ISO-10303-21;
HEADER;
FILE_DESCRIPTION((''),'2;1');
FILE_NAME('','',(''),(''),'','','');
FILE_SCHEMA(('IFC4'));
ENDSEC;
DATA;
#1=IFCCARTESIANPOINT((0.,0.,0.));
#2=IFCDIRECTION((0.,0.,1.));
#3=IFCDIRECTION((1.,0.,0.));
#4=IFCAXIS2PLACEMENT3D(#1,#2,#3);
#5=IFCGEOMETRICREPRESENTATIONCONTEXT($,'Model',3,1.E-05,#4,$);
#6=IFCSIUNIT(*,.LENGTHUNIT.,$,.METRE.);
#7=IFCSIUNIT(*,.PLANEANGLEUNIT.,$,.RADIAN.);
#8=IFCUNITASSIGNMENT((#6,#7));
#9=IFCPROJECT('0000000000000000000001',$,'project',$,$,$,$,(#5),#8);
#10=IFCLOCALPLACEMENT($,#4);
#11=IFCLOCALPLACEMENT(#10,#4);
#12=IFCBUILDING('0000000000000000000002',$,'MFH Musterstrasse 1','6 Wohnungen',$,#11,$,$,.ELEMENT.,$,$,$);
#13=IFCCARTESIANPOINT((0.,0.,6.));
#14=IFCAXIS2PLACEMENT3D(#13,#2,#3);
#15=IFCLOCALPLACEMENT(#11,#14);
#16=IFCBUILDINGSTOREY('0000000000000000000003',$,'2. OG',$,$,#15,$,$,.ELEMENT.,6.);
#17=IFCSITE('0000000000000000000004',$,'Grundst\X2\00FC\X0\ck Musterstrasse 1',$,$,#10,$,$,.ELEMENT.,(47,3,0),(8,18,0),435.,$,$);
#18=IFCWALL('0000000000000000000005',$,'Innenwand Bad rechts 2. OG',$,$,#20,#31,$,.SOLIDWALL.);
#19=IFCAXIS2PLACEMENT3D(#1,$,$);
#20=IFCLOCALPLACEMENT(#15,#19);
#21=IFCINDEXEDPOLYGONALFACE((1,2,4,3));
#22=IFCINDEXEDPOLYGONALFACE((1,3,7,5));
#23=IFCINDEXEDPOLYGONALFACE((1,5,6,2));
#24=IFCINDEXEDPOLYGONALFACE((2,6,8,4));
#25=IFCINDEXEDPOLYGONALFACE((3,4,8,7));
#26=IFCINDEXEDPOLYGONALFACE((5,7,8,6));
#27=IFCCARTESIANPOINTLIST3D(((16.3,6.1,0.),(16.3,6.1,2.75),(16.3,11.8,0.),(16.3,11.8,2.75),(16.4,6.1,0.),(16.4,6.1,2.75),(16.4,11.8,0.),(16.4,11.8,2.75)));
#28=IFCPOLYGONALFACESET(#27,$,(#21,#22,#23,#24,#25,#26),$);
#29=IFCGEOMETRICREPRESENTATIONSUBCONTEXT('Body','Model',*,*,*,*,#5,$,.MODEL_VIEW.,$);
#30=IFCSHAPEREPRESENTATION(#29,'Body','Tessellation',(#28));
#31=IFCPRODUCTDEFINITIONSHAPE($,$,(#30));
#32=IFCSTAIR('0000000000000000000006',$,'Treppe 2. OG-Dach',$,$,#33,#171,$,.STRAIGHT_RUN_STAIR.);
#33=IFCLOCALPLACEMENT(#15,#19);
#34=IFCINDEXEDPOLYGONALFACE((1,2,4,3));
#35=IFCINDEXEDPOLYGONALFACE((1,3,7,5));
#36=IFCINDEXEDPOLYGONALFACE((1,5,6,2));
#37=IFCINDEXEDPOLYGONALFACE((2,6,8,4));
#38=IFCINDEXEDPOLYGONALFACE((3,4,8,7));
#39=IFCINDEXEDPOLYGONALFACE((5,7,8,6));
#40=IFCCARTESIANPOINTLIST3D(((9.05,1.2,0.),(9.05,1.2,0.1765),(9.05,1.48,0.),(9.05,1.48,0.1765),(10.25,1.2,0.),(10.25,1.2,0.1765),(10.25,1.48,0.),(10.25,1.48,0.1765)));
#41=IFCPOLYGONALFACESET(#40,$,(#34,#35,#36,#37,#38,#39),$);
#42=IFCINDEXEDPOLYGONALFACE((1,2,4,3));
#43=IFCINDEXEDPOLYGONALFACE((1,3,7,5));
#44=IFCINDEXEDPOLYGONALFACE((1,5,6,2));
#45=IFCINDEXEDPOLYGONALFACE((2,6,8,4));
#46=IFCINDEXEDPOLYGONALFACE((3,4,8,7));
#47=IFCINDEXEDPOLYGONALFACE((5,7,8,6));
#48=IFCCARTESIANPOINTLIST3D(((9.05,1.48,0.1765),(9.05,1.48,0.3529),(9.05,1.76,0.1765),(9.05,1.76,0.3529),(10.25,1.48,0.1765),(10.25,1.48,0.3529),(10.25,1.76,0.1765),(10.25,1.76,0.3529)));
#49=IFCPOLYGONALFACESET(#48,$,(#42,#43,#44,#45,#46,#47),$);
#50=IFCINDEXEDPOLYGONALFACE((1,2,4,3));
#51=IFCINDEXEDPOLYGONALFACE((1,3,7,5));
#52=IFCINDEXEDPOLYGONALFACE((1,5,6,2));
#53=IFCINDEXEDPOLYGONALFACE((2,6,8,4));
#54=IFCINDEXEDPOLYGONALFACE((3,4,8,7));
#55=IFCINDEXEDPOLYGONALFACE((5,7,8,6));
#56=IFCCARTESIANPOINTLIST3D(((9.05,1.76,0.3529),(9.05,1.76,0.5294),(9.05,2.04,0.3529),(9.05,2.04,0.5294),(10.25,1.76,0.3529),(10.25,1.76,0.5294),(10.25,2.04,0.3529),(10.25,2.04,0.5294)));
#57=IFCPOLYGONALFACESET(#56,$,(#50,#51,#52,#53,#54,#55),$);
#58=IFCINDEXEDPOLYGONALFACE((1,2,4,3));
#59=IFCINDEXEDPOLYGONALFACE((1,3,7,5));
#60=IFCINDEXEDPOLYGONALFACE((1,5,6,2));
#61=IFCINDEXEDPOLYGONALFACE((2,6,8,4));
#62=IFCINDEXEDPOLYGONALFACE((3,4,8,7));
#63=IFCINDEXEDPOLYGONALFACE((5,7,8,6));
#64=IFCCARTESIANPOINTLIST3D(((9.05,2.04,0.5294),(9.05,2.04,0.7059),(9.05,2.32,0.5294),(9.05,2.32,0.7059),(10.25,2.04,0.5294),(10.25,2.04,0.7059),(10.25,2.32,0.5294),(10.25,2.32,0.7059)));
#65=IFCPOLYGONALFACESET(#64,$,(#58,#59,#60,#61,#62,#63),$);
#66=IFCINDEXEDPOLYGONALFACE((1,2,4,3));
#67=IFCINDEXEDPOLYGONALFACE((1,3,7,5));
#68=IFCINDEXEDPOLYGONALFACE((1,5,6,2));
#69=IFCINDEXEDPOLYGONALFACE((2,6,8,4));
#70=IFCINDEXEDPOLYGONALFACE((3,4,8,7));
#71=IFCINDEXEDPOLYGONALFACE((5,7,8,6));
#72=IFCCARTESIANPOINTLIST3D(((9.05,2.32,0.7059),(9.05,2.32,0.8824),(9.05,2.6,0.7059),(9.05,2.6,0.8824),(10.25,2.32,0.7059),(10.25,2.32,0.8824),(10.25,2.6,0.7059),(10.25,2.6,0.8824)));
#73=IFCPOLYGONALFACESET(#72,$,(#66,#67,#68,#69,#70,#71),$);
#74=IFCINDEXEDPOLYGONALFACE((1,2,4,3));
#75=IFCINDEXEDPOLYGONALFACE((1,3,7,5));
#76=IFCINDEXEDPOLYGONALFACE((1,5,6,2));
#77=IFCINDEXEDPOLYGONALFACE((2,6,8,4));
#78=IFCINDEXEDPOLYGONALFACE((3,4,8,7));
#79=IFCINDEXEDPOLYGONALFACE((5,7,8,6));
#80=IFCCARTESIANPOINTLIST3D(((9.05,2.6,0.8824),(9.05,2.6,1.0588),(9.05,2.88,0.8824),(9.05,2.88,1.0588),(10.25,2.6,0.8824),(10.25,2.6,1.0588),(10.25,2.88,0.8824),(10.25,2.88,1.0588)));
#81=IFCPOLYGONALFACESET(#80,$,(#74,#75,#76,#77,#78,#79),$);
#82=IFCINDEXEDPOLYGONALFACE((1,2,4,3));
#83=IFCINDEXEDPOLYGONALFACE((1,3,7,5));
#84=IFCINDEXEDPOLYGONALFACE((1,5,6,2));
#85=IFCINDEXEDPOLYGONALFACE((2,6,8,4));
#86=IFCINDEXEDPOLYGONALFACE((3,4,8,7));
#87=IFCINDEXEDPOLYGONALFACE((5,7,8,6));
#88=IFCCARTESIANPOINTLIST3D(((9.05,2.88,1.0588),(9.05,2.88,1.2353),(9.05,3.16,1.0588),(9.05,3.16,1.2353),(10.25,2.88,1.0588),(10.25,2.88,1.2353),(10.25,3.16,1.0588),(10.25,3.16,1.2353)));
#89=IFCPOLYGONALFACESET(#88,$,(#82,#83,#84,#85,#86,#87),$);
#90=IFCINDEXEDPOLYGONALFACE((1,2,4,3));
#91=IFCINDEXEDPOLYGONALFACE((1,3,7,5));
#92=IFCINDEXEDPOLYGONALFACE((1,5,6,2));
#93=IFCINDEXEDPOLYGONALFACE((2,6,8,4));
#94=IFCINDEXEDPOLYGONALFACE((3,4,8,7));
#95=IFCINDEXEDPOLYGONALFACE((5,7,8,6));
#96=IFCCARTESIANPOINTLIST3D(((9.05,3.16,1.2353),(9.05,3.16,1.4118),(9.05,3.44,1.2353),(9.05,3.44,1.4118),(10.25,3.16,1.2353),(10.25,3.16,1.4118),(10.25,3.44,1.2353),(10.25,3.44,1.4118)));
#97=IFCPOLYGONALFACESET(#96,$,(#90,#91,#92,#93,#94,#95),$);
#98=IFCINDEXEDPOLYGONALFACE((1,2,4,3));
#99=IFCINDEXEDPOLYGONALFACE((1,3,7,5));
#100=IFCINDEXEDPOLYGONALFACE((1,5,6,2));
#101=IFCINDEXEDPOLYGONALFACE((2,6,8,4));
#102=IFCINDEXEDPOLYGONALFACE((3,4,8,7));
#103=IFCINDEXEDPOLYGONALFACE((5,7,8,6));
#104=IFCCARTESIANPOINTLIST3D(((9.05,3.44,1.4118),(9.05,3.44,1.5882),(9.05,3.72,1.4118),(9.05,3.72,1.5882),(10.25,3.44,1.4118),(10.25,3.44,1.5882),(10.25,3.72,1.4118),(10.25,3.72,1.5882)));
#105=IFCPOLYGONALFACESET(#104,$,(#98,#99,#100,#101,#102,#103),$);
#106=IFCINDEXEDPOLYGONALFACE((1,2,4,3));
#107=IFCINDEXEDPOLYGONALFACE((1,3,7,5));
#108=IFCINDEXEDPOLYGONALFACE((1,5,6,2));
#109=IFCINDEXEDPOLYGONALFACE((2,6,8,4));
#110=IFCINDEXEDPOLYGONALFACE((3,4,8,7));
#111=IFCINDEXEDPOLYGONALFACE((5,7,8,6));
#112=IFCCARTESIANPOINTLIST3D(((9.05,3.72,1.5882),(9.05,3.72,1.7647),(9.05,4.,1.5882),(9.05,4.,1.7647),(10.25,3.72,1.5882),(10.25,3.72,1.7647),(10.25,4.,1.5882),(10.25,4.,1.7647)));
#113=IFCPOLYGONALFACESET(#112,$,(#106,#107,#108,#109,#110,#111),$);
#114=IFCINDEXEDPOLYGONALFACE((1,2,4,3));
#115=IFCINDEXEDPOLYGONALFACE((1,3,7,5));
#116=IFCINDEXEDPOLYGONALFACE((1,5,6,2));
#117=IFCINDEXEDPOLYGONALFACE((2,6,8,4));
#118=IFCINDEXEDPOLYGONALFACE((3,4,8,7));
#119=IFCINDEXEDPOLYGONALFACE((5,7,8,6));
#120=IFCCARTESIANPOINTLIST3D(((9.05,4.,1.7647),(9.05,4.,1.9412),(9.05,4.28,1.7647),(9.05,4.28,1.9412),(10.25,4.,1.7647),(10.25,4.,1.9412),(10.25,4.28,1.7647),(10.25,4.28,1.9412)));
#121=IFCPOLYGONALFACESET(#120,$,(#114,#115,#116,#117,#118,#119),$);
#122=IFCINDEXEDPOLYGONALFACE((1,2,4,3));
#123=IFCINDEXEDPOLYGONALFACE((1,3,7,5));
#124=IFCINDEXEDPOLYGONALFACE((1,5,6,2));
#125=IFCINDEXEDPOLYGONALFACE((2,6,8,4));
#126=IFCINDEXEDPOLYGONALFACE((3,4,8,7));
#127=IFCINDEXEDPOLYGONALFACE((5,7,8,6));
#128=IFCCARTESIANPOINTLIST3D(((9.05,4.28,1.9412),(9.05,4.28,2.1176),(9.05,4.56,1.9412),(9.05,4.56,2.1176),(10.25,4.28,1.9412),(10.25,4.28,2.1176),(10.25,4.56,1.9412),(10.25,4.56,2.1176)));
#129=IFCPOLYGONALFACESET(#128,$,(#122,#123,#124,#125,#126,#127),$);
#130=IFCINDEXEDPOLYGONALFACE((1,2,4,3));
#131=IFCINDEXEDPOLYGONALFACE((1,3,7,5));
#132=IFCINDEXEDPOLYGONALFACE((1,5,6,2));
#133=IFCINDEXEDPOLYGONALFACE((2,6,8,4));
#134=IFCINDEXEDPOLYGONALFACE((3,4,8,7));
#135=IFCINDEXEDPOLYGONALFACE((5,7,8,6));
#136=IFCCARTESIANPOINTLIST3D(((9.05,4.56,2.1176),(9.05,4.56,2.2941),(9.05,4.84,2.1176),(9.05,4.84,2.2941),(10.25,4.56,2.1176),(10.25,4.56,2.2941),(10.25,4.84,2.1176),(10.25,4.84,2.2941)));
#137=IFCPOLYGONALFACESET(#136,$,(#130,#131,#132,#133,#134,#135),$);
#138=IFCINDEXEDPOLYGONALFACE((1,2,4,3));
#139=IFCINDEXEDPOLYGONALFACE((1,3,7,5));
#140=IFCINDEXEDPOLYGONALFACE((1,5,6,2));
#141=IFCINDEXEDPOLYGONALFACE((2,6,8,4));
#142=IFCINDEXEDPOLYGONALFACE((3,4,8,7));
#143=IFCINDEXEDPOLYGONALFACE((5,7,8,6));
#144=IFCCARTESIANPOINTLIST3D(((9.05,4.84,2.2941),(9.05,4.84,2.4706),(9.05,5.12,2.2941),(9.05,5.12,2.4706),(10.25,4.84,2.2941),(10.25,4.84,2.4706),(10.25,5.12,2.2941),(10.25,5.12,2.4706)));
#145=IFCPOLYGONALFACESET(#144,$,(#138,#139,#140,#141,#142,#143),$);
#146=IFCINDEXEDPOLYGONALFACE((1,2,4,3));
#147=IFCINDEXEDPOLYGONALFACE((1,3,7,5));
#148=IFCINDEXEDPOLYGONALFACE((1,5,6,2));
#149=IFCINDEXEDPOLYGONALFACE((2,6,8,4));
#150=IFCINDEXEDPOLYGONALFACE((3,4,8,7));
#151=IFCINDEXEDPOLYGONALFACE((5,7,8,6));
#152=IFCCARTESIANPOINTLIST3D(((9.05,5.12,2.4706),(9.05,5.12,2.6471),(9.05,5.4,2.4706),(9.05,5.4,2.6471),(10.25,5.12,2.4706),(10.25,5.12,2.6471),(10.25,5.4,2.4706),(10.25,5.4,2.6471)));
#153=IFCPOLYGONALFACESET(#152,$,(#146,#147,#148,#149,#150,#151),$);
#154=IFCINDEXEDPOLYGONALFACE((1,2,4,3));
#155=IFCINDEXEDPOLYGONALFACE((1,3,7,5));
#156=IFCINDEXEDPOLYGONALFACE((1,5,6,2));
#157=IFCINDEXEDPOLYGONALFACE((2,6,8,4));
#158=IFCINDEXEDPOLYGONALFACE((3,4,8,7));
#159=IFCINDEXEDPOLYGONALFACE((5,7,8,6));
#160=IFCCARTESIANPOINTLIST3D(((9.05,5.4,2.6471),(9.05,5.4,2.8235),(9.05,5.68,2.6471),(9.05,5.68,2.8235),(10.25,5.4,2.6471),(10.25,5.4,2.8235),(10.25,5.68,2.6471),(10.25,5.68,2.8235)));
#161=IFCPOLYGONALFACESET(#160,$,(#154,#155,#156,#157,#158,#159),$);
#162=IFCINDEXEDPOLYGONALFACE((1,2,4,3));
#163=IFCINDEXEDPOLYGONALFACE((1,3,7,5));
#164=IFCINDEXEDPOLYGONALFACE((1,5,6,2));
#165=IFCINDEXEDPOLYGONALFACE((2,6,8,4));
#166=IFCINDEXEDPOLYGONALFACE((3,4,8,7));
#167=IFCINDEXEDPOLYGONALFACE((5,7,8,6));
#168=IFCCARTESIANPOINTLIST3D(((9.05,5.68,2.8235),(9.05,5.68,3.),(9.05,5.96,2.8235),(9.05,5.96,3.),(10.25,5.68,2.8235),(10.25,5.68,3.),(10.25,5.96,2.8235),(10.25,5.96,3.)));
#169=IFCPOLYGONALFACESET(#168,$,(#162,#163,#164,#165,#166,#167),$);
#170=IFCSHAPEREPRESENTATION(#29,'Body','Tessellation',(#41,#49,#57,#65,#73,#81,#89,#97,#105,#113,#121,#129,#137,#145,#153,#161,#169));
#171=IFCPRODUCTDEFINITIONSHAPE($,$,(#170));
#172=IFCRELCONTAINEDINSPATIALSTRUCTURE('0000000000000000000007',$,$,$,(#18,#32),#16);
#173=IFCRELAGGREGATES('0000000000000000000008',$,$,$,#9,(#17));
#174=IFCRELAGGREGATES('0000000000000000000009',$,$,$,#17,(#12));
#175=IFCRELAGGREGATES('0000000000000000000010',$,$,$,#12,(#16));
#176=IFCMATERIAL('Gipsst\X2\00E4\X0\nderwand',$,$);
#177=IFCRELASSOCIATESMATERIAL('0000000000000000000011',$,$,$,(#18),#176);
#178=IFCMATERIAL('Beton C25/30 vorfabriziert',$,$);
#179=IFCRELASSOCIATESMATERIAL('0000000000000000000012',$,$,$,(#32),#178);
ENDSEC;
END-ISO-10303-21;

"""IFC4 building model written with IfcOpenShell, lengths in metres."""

from ifc_helpers import new_model, si_unit, frame, frame_2d, origin_with_axes, place, context, subcontext, project, spatial, rectangle, extrude, material, element, save


model = new_model("IFC4")

# Units and contexts
model_context = context("Model", 3, precision=1e-05, world=origin_with_axes())
body_context = subcontext(model_context, "Body", "Model", "MODEL_VIEW")
ifc_project = project(units=[si_unit("LENGTHUNIT", "METRE"), si_unit("PLANEANGLEUNIT", "RADIAN")], contexts=[model_context])

# Site, building, storey
site_placement = place(None, origin_with_axes())
site = spatial("IfcSite", under=ifc_project, at=site_placement, Name="Grundstück Musterstrasse 1", CompositionType="ELEMENT", RefLatitude=(47, 3, 0), RefLongitude=(8, 18, 0), RefElevation=435.0)
building_placement = place(site_placement, origin_with_axes())
building = spatial("IfcBuilding", under=site, at=building_placement, Name="MFH Musterstrasse 1", Description="6 Wohnungen", CompositionType="ELEMENT")
storey_placement = place(building_placement, frame((0.0, 0.0, 6.0), z_axis=(0.0, 0.0, 1.0), x_axis=(1.0, 0.0, 0.0)))
storey = spatial("IfcBuildingStorey", under=building, at=storey_placement, Name="2. OG", CompositionType="ELEMENT", Elevation=6.0)

# Shared definitions
ifc_material_1 = material(Name="Gipsständerwand")

# Wall
wall_1_placement = place(storey_placement, origin_with_axes())
element("IfcWall", 1, at=wall_1_placement, inside=storey, material=ifc_material_1, Name="Innenwand Bad rechts 2. OG", PredefinedType="SOLIDWALL", context=body_context, shape_type="SweptSolid", body=[
    extrude(rectangle(XDim=0.1, YDim=5.7, at=frame_2d((0.05, 2.85), x_axis=(1.0, 0.0))), frame((16.3, 6.1, 0.0), z_axis=(0.0, 0.0, 1.0), x_axis=(1.0, 0.0, 0.0)), (0.0, 0.0, 1.0), 2.75),
])

# Stair
ifc_material_2 = material(Name="Beton C25/30 vorfabriziert")
stair_placement = place(storey_placement, origin_with_axes())
element("IfcStair", 2, at=stair_placement, inside=storey, material=ifc_material_2, Name="Treppe 2. OG-Dach", PredefinedType="STRAIGHT_RUN_STAIR", context=body_context, shape_type="SweptSolid", body=[
    extrude(rectangle(XDim=1.2, YDim=0.28, at=frame_2d((0.6, 0.14), x_axis=(1.0, 0.0))), frame((9.05, 1.2, 0.0), z_axis=(0.0, 0.0, 1.0), x_axis=(1.0, 0.0, 0.0)), (0.0, 0.0, 1.0), 0.1765),
    extrude(rectangle(XDim=1.2, YDim=0.28, at=frame_2d((0.6, 0.14), x_axis=(1.0, 0.0))), frame((9.05, 1.48, 0.1765), z_axis=(0.0, 0.0, 1.0), x_axis=(1.0, 0.0, 0.0)), (0.0, 0.0, 1.0), 0.1765),
    extrude(rectangle(XDim=1.2, YDim=0.28, at=frame_2d((0.6, 0.14), x_axis=(1.0, 0.0))), frame((9.05, 1.76, 0.3529), z_axis=(0.0, 0.0, 1.0), x_axis=(1.0, 0.0, 0.0)), (0.0, 0.0, 1.0), 0.1765),
    extrude(rectangle(XDim=1.2, YDim=0.28, at=frame_2d((0.6, 0.14), x_axis=(1.0, 0.0))), frame((9.05, 2.04, 0.5294), z_axis=(0.0, 0.0, 1.0), x_axis=(1.0, 0.0, 0.0)), (0.0, 0.0, 1.0), 0.1765),
    extrude(rectangle(XDim=1.2, YDim=0.28, at=frame_2d((0.6, 0.14), x_axis=(1.0, 0.0))), frame((9.05, 2.32, 0.7059), z_axis=(0.0, 0.0, 1.0), x_axis=(1.0, 0.0, 0.0)), (0.0, 0.0, 1.0), 0.1765),
    extrude(rectangle(XDim=1.2, YDim=0.28, at=frame_2d((0.6, 0.14), x_axis=(1.0, 0.0))), frame((9.05, 2.6, 0.8824), z_axis=(0.0, 0.0, 1.0), x_axis=(1.0, 0.0, 0.0)), (0.0, 0.0, 1.0), 0.1765),
    extrude(rectangle(XDim=1.2, YDim=0.28, at=frame_2d((0.6, 0.14), x_axis=(1.0, 0.0))), frame((9.05, 2.88, 1.0588), z_axis=(0.0, 0.0, 1.0), x_axis=(1.0, 0.0, 0.0)), (0.0, 0.0, 1.0), 0.1765),
    extrude(rectangle(XDim=1.2, YDim=0.28, at=frame_2d((0.6, 0.14), x_axis=(1.0, 0.0))), frame((9.05, 3.16, 1.2353), z_axis=(0.0, 0.0, 1.0), x_axis=(1.0, 0.0, 0.0)), (0.0, 0.0, 1.0), 0.1765),
    extrude(rectangle(XDim=1.2, YDim=0.28, at=frame_2d((0.6, 0.14), x_axis=(1.0, 0.0))), frame((9.05, 3.44, 1.4118), z_axis=(0.0, 0.0, 1.0), x_axis=(1.0, 0.0, 0.0)), (0.0, 0.0, 1.0), 0.1765),
    extrude(rectangle(XDim=1.2, YDim=0.28, at=frame_2d((0.6, 0.14), x_axis=(1.0, 0.0))), frame((9.05, 3.72, 1.5882), z_axis=(0.0, 0.0, 1.0), x_axis=(1.0, 0.0, 0.0)), (0.0, 0.0, 1.0), 0.1765),
    extrude(rectangle(XDim=1.2, YDim=0.28, at=frame_2d((0.6, 0.14), x_axis=(1.0, 0.0))), frame((9.05, 4.0, 1.7647), z_axis=(0.0, 0.0, 1.0), x_axis=(1.0, 0.0, 0.0)), (0.0, 0.0, 1.0), 0.1765),
    extrude(rectangle(XDim=1.2, YDim=0.28, at=frame_2d((0.6, 0.14), x_axis=(1.0, 0.0))), frame((9.05, 4.28, 1.9412), z_axis=(0.0, 0.0, 1.0), x_axis=(1.0, 0.0, 0.0)), (0.0, 0.0, 1.0), 0.1765),
    extrude(rectangle(XDim=1.2, YDim=0.28, at=frame_2d((0.6, 0.14), x_axis=(1.0, 0.0))), frame((9.05, 4.56, 2.1176), z_axis=(0.0, 0.0, 1.0), x_axis=(1.0, 0.0, 0.0)), (0.0, 0.0, 1.0), 0.1765),
    extrude(rectangle(XDim=1.2, YDim=0.28, at=frame_2d((0.6, 0.14), x_axis=(1.0, 0.0))), frame((9.05, 4.84, 2.2941), z_axis=(0.0, 0.0, 1.0), x_axis=(1.0, 0.0, 0.0)), (0.0, 0.0, 1.0), 0.1765),
    extrude(rectangle(XDim=1.2, YDim=0.28, at=frame_2d((0.6, 0.14), x_axis=(1.0, 0.0))), frame((9.05, 5.12, 2.4706), z_axis=(0.0, 0.0, 1.0), x_axis=(1.0, 0.0, 0.0)), (0.0, 0.0, 1.0), 0.1765),
    extrude(rectangle(XDim=1.2, YDim=0.28, at=frame_2d((0.6, 0.14), x_axis=(1.0, 0.0))), frame((9.05, 5.4, 2.6471), z_axis=(0.0, 0.0, 1.0), x_axis=(1.0, 0.0, 0.0)), (0.0, 0.0, 1.0), 0.1765),
    extrude(rectangle(XDim=1.2, YDim=0.28, at=frame_2d((0.6, 0.14), x_axis=(1.0, 0.0))), frame((9.05, 5.68, 2.8235), z_axis=(0.0, 0.0, 1.0), x_axis=(1.0, 0.0, 0.0)), (0.0, 0.0, 1.0), 0.1765),
])

save(model, "model.ifc")
